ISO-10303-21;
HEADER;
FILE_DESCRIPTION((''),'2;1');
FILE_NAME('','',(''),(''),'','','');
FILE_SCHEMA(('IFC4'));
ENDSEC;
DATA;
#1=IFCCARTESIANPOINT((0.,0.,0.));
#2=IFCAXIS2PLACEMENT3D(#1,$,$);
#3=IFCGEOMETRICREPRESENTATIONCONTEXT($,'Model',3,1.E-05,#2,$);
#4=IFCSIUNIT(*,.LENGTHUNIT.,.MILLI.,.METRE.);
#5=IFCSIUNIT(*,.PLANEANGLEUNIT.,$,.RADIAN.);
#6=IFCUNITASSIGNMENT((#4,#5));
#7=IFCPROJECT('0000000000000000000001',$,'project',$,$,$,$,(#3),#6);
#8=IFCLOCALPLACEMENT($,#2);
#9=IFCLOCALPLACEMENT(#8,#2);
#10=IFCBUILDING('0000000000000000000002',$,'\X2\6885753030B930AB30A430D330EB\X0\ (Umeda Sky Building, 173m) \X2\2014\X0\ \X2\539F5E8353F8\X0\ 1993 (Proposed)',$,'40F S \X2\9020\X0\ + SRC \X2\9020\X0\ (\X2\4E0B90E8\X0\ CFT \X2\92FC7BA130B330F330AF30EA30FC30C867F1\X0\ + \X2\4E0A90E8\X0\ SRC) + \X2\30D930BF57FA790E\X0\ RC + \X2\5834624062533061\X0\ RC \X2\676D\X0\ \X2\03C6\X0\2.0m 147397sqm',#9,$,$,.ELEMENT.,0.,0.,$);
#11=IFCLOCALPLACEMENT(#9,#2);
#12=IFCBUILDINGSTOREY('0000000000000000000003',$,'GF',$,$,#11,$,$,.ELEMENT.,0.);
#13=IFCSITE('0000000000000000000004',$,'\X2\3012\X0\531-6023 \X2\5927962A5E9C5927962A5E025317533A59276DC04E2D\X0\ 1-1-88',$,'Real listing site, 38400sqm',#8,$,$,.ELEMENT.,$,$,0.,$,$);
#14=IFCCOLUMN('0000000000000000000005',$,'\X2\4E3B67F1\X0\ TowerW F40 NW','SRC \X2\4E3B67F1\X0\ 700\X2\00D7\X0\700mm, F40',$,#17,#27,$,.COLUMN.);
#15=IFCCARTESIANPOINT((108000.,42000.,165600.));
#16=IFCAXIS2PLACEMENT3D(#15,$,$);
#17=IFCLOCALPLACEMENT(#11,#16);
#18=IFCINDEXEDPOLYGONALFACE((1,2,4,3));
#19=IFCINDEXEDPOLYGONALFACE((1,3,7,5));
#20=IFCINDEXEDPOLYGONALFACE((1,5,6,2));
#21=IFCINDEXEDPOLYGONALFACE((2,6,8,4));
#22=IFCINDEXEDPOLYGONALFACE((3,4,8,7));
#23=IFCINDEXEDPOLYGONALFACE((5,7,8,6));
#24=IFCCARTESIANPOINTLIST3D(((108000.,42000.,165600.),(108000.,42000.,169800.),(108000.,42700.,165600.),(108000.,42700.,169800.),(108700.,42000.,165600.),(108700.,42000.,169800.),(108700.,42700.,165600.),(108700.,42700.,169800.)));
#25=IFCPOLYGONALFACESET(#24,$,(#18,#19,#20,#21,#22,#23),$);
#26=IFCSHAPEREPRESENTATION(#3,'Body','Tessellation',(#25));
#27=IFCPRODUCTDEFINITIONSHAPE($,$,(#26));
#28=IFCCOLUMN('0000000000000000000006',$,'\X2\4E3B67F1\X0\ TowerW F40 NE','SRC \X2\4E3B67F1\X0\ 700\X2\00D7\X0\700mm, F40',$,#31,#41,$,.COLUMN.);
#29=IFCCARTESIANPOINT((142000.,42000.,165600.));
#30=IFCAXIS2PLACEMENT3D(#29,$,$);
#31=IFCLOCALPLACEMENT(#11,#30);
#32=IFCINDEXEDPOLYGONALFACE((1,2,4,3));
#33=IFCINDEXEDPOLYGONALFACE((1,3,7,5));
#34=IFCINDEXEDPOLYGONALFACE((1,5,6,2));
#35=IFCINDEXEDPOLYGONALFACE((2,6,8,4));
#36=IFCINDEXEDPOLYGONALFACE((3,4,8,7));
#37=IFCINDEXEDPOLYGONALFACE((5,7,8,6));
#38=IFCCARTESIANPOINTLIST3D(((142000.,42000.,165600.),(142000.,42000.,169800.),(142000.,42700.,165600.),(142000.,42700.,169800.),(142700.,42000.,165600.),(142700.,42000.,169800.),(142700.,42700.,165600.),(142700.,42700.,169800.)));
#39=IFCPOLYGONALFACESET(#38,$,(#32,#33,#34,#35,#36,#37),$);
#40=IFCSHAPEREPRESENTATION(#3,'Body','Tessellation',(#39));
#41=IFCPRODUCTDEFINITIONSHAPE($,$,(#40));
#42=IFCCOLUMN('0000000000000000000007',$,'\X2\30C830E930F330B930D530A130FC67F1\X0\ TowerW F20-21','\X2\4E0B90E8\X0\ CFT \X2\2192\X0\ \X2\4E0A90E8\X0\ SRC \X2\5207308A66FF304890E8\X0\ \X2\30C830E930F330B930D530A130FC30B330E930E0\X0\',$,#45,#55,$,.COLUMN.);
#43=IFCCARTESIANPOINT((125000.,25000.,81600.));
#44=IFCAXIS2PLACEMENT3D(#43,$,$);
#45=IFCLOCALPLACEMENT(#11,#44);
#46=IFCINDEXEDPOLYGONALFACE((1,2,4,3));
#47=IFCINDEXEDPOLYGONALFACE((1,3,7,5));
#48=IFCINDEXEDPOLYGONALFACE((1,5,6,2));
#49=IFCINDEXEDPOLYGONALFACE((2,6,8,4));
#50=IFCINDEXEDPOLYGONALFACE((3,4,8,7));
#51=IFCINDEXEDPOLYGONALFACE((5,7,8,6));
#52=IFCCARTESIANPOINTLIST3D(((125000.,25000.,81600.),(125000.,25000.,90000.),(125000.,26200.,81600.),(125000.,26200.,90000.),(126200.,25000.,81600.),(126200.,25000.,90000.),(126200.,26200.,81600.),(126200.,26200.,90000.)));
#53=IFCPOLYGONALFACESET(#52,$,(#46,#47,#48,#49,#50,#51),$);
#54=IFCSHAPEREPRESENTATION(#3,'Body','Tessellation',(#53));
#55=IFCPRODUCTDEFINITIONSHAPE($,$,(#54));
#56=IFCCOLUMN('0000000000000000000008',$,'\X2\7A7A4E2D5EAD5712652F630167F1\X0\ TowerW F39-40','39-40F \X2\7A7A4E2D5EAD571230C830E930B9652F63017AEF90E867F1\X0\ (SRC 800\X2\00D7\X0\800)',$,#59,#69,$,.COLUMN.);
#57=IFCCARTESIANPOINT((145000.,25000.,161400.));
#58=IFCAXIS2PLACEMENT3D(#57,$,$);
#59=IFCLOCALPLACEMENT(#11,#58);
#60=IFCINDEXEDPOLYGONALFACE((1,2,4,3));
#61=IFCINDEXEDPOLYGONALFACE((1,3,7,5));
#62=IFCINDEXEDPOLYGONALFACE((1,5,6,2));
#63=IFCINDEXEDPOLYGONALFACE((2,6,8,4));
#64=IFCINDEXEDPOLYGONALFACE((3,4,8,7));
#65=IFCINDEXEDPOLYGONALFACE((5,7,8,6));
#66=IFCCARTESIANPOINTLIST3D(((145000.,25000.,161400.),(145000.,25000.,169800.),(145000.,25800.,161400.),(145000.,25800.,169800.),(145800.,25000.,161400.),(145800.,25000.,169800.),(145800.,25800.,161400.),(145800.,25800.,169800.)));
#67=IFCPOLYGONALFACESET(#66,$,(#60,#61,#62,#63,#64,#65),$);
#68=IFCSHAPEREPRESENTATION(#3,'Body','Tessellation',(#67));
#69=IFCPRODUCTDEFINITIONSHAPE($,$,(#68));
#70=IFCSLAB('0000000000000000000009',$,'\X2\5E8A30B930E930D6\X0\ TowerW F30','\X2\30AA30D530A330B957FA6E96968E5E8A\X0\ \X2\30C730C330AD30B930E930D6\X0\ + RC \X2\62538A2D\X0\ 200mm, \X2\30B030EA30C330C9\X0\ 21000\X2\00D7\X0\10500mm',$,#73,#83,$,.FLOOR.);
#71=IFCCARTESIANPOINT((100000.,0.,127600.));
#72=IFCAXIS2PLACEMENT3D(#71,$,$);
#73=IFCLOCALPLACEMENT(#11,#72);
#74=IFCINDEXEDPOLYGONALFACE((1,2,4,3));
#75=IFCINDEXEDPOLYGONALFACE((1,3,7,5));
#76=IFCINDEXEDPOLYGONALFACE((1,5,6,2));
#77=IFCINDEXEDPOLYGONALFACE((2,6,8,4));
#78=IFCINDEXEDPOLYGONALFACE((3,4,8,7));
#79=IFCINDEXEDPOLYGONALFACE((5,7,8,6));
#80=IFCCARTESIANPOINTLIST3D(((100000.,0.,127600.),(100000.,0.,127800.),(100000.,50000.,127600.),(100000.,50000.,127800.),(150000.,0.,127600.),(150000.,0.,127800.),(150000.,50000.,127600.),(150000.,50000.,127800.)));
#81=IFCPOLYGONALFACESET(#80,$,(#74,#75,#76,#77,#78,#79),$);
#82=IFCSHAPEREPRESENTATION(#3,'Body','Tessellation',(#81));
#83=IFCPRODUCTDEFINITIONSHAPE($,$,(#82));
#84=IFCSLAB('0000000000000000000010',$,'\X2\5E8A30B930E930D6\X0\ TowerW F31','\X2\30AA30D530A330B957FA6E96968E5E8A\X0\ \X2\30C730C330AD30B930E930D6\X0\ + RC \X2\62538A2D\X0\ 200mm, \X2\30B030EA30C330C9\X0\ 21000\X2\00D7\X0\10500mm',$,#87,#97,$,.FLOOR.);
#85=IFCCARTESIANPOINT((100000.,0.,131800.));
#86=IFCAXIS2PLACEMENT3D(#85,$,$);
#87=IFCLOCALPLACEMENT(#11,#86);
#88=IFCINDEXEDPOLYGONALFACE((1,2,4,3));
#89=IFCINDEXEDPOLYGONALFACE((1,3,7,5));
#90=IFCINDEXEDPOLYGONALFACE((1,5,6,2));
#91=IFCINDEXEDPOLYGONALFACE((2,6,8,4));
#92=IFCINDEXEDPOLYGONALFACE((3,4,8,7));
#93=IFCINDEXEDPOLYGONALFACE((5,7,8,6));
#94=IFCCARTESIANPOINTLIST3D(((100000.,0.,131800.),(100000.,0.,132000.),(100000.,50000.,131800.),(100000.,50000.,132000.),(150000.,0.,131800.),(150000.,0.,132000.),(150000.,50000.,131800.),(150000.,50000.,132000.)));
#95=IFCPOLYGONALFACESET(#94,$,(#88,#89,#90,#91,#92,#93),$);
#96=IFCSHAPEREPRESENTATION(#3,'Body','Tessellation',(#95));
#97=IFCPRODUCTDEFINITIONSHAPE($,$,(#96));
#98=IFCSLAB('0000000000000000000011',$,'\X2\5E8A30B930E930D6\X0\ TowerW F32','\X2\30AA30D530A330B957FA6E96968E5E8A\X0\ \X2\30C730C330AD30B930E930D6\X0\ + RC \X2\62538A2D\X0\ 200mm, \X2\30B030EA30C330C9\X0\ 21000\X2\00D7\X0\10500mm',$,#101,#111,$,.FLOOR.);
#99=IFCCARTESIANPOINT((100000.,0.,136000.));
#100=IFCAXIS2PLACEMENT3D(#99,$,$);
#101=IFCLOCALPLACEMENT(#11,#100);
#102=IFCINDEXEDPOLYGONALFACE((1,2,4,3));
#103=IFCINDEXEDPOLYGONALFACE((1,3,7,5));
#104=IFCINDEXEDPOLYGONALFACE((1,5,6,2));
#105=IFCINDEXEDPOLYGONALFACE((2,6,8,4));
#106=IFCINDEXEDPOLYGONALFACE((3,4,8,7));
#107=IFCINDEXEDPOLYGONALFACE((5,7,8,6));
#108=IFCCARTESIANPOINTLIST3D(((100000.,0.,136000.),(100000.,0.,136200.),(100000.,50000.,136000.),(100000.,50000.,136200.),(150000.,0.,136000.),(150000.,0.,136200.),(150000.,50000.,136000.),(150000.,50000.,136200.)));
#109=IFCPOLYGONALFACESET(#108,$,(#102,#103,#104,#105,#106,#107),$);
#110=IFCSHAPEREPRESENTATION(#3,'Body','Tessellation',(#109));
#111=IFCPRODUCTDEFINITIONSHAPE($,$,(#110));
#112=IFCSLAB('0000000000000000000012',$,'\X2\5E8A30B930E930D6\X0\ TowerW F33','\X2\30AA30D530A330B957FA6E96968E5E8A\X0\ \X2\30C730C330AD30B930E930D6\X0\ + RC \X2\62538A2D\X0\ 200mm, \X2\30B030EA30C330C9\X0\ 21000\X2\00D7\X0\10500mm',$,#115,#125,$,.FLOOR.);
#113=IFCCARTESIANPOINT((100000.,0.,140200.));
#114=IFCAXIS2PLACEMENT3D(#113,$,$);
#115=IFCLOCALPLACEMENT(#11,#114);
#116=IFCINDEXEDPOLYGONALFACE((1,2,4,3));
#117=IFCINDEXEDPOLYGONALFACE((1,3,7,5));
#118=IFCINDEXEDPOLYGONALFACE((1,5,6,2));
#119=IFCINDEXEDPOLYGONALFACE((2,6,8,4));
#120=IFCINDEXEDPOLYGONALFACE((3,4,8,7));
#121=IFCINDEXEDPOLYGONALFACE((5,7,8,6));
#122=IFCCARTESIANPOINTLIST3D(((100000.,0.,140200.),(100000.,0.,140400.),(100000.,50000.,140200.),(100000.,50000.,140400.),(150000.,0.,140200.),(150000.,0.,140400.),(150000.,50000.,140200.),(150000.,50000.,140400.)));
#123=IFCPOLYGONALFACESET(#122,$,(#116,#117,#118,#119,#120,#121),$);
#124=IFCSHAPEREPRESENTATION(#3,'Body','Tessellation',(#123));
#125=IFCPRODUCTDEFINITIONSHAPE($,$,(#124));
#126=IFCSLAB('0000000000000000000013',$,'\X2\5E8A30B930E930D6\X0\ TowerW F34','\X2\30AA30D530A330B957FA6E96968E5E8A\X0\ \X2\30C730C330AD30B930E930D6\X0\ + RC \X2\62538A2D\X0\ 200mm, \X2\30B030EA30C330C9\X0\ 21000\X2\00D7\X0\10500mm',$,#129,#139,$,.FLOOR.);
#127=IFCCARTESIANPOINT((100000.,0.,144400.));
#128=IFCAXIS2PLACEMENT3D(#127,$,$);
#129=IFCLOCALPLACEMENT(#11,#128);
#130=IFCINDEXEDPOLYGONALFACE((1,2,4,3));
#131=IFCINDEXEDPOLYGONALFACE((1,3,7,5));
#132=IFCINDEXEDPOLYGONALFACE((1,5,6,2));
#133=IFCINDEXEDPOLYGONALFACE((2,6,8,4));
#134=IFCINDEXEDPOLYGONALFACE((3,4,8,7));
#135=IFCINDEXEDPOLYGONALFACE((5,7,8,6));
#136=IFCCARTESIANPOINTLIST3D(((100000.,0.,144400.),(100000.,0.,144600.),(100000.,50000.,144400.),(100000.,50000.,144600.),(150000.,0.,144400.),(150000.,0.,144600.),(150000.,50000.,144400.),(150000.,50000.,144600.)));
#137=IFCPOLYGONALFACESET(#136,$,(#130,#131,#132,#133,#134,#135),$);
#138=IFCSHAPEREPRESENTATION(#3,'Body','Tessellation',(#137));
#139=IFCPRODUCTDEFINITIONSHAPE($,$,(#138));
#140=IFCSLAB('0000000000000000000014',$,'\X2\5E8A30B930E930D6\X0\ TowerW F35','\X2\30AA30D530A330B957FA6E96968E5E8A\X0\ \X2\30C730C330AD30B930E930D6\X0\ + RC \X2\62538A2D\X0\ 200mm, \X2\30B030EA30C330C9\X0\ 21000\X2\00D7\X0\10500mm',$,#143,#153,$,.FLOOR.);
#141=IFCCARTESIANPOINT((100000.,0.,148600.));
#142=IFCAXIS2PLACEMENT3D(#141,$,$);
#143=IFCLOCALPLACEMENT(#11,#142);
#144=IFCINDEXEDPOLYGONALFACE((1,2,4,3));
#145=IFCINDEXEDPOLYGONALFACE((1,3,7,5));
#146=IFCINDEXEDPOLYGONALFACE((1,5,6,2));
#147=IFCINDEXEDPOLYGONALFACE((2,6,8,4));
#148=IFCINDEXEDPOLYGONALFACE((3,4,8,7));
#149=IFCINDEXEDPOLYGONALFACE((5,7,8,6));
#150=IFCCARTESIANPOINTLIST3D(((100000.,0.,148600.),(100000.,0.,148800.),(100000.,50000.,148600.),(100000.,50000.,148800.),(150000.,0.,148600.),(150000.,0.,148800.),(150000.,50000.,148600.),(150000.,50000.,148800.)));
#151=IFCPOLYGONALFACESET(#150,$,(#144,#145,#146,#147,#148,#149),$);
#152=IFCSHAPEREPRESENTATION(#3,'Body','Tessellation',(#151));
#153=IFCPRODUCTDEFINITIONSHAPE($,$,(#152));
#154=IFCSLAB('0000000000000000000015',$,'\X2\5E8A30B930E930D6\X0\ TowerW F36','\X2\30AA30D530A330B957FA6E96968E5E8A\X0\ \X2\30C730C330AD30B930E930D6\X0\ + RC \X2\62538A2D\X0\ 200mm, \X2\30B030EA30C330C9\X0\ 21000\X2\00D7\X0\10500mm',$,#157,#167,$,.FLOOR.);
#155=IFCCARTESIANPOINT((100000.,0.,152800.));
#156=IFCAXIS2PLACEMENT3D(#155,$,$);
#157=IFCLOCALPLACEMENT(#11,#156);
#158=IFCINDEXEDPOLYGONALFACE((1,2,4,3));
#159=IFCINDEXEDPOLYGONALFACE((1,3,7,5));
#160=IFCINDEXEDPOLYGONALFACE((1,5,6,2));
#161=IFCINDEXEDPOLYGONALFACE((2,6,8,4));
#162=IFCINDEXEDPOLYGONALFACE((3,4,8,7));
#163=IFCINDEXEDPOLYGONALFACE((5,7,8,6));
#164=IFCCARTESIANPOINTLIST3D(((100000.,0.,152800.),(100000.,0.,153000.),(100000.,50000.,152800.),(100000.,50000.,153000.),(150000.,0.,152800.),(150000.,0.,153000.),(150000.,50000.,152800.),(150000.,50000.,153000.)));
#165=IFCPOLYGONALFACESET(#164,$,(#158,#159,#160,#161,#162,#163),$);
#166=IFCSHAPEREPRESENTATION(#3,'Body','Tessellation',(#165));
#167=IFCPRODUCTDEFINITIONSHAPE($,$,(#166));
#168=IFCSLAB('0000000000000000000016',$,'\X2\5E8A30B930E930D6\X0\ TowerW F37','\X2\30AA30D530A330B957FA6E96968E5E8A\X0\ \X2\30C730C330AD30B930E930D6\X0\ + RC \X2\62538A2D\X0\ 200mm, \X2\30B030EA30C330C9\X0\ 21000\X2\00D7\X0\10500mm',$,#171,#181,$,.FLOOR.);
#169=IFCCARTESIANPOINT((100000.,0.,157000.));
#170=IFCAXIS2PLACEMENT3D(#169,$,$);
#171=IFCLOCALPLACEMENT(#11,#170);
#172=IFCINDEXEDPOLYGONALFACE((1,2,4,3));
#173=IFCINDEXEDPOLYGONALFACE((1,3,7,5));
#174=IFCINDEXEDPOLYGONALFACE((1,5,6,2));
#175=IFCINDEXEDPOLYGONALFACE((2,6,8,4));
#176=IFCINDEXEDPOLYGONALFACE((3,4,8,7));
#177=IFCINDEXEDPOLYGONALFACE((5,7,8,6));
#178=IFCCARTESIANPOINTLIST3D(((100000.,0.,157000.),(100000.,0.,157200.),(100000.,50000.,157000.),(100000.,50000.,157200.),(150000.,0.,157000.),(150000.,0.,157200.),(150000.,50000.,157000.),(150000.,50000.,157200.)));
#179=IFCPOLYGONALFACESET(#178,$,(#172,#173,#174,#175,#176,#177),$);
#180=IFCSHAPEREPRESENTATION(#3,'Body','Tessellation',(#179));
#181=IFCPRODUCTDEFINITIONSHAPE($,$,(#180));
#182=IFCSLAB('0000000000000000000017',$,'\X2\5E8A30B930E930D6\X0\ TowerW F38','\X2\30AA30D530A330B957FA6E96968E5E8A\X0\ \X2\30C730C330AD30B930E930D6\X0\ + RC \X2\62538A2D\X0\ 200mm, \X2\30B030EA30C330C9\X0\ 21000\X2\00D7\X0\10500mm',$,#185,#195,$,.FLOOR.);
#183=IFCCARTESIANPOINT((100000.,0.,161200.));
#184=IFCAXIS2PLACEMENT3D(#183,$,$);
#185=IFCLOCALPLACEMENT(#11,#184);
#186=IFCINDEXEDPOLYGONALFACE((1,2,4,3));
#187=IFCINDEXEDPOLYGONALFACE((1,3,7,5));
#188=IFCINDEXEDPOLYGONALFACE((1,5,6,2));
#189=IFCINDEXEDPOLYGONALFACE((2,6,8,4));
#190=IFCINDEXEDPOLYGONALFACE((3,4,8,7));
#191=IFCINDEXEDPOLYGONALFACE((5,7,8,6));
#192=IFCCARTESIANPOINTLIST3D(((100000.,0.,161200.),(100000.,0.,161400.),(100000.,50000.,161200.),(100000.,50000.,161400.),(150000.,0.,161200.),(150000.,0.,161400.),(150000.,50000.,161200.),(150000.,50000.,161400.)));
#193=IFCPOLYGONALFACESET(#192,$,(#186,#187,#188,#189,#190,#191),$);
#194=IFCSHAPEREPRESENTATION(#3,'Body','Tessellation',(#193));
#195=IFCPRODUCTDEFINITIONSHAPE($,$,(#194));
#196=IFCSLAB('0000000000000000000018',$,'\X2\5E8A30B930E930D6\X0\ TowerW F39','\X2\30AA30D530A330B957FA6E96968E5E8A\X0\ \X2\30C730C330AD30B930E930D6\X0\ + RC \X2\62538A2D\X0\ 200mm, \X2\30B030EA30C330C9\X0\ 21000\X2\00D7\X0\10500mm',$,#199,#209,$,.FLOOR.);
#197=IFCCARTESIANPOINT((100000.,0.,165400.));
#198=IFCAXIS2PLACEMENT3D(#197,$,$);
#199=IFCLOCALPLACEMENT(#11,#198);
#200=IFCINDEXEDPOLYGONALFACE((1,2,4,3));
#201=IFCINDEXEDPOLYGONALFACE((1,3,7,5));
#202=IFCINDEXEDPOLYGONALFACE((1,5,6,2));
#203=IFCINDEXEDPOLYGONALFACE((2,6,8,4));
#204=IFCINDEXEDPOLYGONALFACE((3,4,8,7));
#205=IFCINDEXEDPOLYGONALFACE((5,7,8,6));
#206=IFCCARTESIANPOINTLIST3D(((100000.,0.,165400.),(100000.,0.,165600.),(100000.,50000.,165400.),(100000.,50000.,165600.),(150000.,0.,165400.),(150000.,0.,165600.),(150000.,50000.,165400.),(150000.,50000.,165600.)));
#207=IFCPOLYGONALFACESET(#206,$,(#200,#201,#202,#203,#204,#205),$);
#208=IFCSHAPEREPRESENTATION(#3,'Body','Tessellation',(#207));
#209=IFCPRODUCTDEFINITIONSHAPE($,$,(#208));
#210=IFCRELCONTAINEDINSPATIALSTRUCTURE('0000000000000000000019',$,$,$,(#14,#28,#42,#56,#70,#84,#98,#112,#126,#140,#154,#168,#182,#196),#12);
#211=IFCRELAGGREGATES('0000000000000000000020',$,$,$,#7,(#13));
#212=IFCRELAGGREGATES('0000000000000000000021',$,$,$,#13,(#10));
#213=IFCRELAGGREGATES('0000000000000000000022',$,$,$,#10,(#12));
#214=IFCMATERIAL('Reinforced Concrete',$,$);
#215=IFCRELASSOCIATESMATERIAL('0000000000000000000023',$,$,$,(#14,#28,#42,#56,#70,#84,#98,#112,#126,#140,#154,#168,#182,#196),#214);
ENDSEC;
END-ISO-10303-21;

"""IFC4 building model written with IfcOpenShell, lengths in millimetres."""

from ifc_helpers import new_model, si_unit, frame, frame_2d, origin, place, context, project, spatial, rectangle, extrude, material, element, save


model = new_model("IFC4")

# Units and contexts
model_context = context("Model", 3, precision=1e-05, world=origin())
ifc_project = project(units=[si_unit("LENGTHUNIT", "METRE", prefix="MILLI"), si_unit("PLANEANGLEUNIT", "RADIAN")], contexts=[model_context])

# Site, building, storey
site_placement = place(None, origin())
site = spatial("IfcSite", under=ifc_project, at=site_placement, Name="〒531-6023 大阪府大阪市北区大淀中 1-1-88", ObjectType="Real listing site, 38400sqm", CompositionType="ELEMENT", RefElevation=0.0)
building_placement = place(site_placement, origin())
building = spatial("IfcBuilding", under=site, at=building_placement, Name="梅田スカイビル (Umeda Sky Building, 173m) — 原広司 1993 (Proposed)", ObjectType="40F S 造 + SRC 造 (下部 CFT 鋼管コンクリート柱 + 上部 SRC) + ベタ基礎 RC + 場所打ち RC 杭 φ2.0m 147397sqm", CompositionType="ELEMENT", ElevationOfRefHeight=0.0, ElevationOfTerrain=0.0)
storey_placement = place(building_placement, origin())
storey = spatial("IfcBuildingStorey", under=building, at=storey_placement, Name="GF", CompositionType="ELEMENT", Elevation=0.0)

# Columns
ifc_material_1 = material(Name="Reinforced Concrete")
column_1_placement = place(storey_placement, frame((108000.0, 42000.0, 165600.0)))
element("IfcColumn", 1, at=column_1_placement, inside=storey, material=ifc_material_1, Name="主柱 TowerW F40 NW", Description="SRC 主柱 700×700mm, F40", PredefinedType="COLUMN", context=model_context, shape_type="SweptSolid", body=[
    extrude(rectangle(XDim=700.0, YDim=700.0, at=frame_2d((350.0, 350.0))), frame((108000.0, 42000.0, 165600.0)), (0.0, 0.0, 1.0), 4200.0),
])
column_2_placement = place(storey_placement, frame((142000.0, 42000.0, 165600.0)))
element("IfcColumn", 2, at=column_2_placement, inside=storey, material=ifc_material_1, Name="主柱 TowerW F40 NE", Description="SRC 主柱 700×700mm, F40", PredefinedType="COLUMN", context=model_context, shape_type="SweptSolid", body=[
    extrude(rectangle(XDim=700.0, YDim=700.0, at=frame_2d((350.0, 350.0))), frame((142000.0, 42000.0, 165600.0)), (0.0, 0.0, 1.0), 4200.0),
])
column_3_placement = place(storey_placement, frame((125000.0, 25000.0, 81600.0)))
element("IfcColumn", 3, at=column_3_placement, inside=storey, material=ifc_material_1, Name="トランスファー柱 TowerW F20-21", Description="下部 CFT → 上部 SRC 切り替え部 トランスファーコラム", PredefinedType="COLUMN", context=model_context, shape_type="SweptSolid", body=[
    extrude(rectangle(XDim=1200.0, YDim=1200.0, at=frame_2d((600.0, 600.0))), frame((125000.0, 25000.0, 81600.0)), (0.0, 0.0, 1.0), 8400.0),
])
column_4_placement = place(storey_placement, frame((145000.0, 25000.0, 161400.0)))
element("IfcColumn", 4, at=column_4_placement, inside=storey, material=ifc_material_1, Name="空中庭園支持柱 TowerW F39-40", Description="39-40F 空中庭園トラス支持端部柱 (SRC 800×800)", PredefinedType="COLUMN", context=model_context, shape_type="SweptSolid", body=[
    extrude(rectangle(XDim=800.0, YDim=800.0, at=frame_2d((400.0, 400.0))), frame((145000.0, 25000.0, 161400.0)), (0.0, 0.0, 1.0), 8400.0),
])

# Slabs
slab_1_placement = place(storey_placement, frame((100000.0, 0.0, 127600.0)))
element("IfcSlab", 5, at=slab_1_placement, inside=storey, material=ifc_material_1, Name="床スラブ TowerW F30", Description="オフィス基準階床 デッキスラブ + RC 打設 200mm, グリッド 21000×10500mm", PredefinedType="FLOOR", context=model_context, shape_type="SweptSolid", body=[
    extrude(rectangle(XDim=50000.0, YDim=50000.0, at=frame_2d((25000.0, 25000.0))), frame((100000.0, 0.0, 127600.0)), (0.0, 0.0, 1.0), 200.0),
])
slab_2_placement = place(storey_placement, frame((100000.0, 0.0, 131800.0)))
element("IfcSlab", 6, at=slab_2_placement, inside=storey, material=ifc_material_1, Name="床スラブ TowerW F31", Description="オフィス基準階床 デッキスラブ + RC 打設 200mm, グリッド 21000×10500mm", PredefinedType="FLOOR", context=model_context, shape_type="SweptSolid", body=[
    extrude(rectangle(XDim=50000.0, YDim=50000.0, at=frame_2d((25000.0, 25000.0))), frame((100000.0, 0.0, 131800.0)), (0.0, 0.0, 1.0), 200.0),
])
slab_3_placement = place(storey_placement, frame((100000.0, 0.0, 136000.0)))
element("IfcSlab", 7, at=slab_3_placement, inside=storey, material=ifc_material_1, Name="床スラブ TowerW F32", Description="オフィス基準階床 デッキスラブ + RC 打設 200mm, グリッド 21000×10500mm", PredefinedType="FLOOR", context=model_context, shape_type="SweptSolid", body=[
    extrude(rectangle(XDim=50000.0, YDim=50000.0, at=frame_2d((25000.0, 25000.0))), frame((100000.0, 0.0, 136000.0)), (0.0, 0.0, 1.0), 200.0),
])
slab_4_placement = place(storey_placement, frame((100000.0, 0.0, 140200.0)))
element("IfcSlab", 8, at=slab_4_placement, inside=storey, material=ifc_material_1, Name="床スラブ TowerW F33", Description="オフィス基準階床 デッキスラブ + RC 打設 200mm, グリッド 21000×10500mm", PredefinedType="FLOOR", context=model_context, shape_type="SweptSolid", body=[
    extrude(rectangle(XDim=50000.0, YDim=50000.0, at=frame_2d((25000.0, 25000.0))), frame((100000.0, 0.0, 140200.0)), (0.0, 0.0, 1.0), 200.0),
])
slab_5_placement = place(storey_placement, frame((100000.0, 0.0, 144400.0)))
element("IfcSlab", 9, at=slab_5_placement, inside=storey, material=ifc_material_1, Name="床スラブ TowerW F34", Description="オフィス基準階床 デッキスラブ + RC 打設 200mm, グリッド 21000×10500mm", PredefinedType="FLOOR", context=model_context, shape_type="SweptSolid", body=[
    extrude(rectangle(XDim=50000.0, YDim=50000.0, at=frame_2d((25000.0, 25000.0))), frame((100000.0, 0.0, 144400.0)), (0.0, 0.0, 1.0), 200.0),
])
slab_6_placement = place(storey_placement, frame((100000.0, 0.0, 148600.0)))
element("IfcSlab", 10, at=slab_6_placement, inside=storey, material=ifc_material_1, Name="床スラブ TowerW F35", Description="オフィス基準階床 デッキスラブ + RC 打設 200mm, グリッド 21000×10500mm", PredefinedType="FLOOR", context=model_context, shape_type="SweptSolid", body=[
    extrude(rectangle(XDim=50000.0, YDim=50000.0, at=frame_2d((25000.0, 25000.0))), frame((100000.0, 0.0, 148600.0)), (0.0, 0.0, 1.0), 200.0),
])
slab_7_placement = place(storey_placement, frame((100000.0, 0.0, 152800.0)))
element("IfcSlab", 11, at=slab_7_placement, inside=storey, material=ifc_material_1, Name="床スラブ TowerW F36", Description="オフィス基準階床 デッキスラブ + RC 打設 200mm, グリッド 21000×10500mm", PredefinedType="FLOOR", context=model_context, shape_type="SweptSolid", body=[
    extrude(rectangle(XDim=50000.0, YDim=50000.0, at=frame_2d((25000.0, 25000.0))), frame((100000.0, 0.0, 152800.0)), (0.0, 0.0, 1.0), 200.0),
])
slab_8_placement = place(storey_placement, frame((100000.0, 0.0, 157000.0)))
element("IfcSlab", 12, at=slab_8_placement, inside=storey, material=ifc_material_1, Name="床スラブ TowerW F37", Description="オフィス基準階床 デッキスラブ + RC 打設 200mm, グリッド 21000×10500mm", PredefinedType="FLOOR", context=model_context, shape_type="SweptSolid", body=[
    extrude(rectangle(XDim=50000.0, YDim=50000.0, at=frame_2d((25000.0, 25000.0))), frame((100000.0, 0.0, 157000.0)), (0.0, 0.0, 1.0), 200.0),
])
slab_9_placement = place(storey_placement, frame((100000.0, 0.0, 161200.0)))
element("IfcSlab", 13, at=slab_9_placement, inside=storey, material=ifc_material_1, Name="床スラブ TowerW F38", Description="オフィス基準階床 デッキスラブ + RC 打設 200mm, グリッド 21000×10500mm", PredefinedType="FLOOR", context=model_context, shape_type="SweptSolid", body=[
    extrude(rectangle(XDim=50000.0, YDim=50000.0, at=frame_2d((25000.0, 25000.0))), frame((100000.0, 0.0, 161200.0)), (0.0, 0.0, 1.0), 200.0),
])
slab_10_placement = place(storey_placement, frame((100000.0, 0.0, 165400.0)))
element("IfcSlab", 14, at=slab_10_placement, inside=storey, material=ifc_material_1, Name="床スラブ TowerW F39", Description="オフィス基準階床 デッキスラブ + RC 打設 200mm, グリッド 21000×10500mm", PredefinedType="FLOOR", context=model_context, shape_type="SweptSolid", body=[
    extrude(rectangle(XDim=50000.0, YDim=50000.0, at=frame_2d((25000.0, 25000.0))), frame((100000.0, 0.0, 165400.0)), (0.0, 0.0, 1.0), 200.0),
])

save(model, "model.ifc")
